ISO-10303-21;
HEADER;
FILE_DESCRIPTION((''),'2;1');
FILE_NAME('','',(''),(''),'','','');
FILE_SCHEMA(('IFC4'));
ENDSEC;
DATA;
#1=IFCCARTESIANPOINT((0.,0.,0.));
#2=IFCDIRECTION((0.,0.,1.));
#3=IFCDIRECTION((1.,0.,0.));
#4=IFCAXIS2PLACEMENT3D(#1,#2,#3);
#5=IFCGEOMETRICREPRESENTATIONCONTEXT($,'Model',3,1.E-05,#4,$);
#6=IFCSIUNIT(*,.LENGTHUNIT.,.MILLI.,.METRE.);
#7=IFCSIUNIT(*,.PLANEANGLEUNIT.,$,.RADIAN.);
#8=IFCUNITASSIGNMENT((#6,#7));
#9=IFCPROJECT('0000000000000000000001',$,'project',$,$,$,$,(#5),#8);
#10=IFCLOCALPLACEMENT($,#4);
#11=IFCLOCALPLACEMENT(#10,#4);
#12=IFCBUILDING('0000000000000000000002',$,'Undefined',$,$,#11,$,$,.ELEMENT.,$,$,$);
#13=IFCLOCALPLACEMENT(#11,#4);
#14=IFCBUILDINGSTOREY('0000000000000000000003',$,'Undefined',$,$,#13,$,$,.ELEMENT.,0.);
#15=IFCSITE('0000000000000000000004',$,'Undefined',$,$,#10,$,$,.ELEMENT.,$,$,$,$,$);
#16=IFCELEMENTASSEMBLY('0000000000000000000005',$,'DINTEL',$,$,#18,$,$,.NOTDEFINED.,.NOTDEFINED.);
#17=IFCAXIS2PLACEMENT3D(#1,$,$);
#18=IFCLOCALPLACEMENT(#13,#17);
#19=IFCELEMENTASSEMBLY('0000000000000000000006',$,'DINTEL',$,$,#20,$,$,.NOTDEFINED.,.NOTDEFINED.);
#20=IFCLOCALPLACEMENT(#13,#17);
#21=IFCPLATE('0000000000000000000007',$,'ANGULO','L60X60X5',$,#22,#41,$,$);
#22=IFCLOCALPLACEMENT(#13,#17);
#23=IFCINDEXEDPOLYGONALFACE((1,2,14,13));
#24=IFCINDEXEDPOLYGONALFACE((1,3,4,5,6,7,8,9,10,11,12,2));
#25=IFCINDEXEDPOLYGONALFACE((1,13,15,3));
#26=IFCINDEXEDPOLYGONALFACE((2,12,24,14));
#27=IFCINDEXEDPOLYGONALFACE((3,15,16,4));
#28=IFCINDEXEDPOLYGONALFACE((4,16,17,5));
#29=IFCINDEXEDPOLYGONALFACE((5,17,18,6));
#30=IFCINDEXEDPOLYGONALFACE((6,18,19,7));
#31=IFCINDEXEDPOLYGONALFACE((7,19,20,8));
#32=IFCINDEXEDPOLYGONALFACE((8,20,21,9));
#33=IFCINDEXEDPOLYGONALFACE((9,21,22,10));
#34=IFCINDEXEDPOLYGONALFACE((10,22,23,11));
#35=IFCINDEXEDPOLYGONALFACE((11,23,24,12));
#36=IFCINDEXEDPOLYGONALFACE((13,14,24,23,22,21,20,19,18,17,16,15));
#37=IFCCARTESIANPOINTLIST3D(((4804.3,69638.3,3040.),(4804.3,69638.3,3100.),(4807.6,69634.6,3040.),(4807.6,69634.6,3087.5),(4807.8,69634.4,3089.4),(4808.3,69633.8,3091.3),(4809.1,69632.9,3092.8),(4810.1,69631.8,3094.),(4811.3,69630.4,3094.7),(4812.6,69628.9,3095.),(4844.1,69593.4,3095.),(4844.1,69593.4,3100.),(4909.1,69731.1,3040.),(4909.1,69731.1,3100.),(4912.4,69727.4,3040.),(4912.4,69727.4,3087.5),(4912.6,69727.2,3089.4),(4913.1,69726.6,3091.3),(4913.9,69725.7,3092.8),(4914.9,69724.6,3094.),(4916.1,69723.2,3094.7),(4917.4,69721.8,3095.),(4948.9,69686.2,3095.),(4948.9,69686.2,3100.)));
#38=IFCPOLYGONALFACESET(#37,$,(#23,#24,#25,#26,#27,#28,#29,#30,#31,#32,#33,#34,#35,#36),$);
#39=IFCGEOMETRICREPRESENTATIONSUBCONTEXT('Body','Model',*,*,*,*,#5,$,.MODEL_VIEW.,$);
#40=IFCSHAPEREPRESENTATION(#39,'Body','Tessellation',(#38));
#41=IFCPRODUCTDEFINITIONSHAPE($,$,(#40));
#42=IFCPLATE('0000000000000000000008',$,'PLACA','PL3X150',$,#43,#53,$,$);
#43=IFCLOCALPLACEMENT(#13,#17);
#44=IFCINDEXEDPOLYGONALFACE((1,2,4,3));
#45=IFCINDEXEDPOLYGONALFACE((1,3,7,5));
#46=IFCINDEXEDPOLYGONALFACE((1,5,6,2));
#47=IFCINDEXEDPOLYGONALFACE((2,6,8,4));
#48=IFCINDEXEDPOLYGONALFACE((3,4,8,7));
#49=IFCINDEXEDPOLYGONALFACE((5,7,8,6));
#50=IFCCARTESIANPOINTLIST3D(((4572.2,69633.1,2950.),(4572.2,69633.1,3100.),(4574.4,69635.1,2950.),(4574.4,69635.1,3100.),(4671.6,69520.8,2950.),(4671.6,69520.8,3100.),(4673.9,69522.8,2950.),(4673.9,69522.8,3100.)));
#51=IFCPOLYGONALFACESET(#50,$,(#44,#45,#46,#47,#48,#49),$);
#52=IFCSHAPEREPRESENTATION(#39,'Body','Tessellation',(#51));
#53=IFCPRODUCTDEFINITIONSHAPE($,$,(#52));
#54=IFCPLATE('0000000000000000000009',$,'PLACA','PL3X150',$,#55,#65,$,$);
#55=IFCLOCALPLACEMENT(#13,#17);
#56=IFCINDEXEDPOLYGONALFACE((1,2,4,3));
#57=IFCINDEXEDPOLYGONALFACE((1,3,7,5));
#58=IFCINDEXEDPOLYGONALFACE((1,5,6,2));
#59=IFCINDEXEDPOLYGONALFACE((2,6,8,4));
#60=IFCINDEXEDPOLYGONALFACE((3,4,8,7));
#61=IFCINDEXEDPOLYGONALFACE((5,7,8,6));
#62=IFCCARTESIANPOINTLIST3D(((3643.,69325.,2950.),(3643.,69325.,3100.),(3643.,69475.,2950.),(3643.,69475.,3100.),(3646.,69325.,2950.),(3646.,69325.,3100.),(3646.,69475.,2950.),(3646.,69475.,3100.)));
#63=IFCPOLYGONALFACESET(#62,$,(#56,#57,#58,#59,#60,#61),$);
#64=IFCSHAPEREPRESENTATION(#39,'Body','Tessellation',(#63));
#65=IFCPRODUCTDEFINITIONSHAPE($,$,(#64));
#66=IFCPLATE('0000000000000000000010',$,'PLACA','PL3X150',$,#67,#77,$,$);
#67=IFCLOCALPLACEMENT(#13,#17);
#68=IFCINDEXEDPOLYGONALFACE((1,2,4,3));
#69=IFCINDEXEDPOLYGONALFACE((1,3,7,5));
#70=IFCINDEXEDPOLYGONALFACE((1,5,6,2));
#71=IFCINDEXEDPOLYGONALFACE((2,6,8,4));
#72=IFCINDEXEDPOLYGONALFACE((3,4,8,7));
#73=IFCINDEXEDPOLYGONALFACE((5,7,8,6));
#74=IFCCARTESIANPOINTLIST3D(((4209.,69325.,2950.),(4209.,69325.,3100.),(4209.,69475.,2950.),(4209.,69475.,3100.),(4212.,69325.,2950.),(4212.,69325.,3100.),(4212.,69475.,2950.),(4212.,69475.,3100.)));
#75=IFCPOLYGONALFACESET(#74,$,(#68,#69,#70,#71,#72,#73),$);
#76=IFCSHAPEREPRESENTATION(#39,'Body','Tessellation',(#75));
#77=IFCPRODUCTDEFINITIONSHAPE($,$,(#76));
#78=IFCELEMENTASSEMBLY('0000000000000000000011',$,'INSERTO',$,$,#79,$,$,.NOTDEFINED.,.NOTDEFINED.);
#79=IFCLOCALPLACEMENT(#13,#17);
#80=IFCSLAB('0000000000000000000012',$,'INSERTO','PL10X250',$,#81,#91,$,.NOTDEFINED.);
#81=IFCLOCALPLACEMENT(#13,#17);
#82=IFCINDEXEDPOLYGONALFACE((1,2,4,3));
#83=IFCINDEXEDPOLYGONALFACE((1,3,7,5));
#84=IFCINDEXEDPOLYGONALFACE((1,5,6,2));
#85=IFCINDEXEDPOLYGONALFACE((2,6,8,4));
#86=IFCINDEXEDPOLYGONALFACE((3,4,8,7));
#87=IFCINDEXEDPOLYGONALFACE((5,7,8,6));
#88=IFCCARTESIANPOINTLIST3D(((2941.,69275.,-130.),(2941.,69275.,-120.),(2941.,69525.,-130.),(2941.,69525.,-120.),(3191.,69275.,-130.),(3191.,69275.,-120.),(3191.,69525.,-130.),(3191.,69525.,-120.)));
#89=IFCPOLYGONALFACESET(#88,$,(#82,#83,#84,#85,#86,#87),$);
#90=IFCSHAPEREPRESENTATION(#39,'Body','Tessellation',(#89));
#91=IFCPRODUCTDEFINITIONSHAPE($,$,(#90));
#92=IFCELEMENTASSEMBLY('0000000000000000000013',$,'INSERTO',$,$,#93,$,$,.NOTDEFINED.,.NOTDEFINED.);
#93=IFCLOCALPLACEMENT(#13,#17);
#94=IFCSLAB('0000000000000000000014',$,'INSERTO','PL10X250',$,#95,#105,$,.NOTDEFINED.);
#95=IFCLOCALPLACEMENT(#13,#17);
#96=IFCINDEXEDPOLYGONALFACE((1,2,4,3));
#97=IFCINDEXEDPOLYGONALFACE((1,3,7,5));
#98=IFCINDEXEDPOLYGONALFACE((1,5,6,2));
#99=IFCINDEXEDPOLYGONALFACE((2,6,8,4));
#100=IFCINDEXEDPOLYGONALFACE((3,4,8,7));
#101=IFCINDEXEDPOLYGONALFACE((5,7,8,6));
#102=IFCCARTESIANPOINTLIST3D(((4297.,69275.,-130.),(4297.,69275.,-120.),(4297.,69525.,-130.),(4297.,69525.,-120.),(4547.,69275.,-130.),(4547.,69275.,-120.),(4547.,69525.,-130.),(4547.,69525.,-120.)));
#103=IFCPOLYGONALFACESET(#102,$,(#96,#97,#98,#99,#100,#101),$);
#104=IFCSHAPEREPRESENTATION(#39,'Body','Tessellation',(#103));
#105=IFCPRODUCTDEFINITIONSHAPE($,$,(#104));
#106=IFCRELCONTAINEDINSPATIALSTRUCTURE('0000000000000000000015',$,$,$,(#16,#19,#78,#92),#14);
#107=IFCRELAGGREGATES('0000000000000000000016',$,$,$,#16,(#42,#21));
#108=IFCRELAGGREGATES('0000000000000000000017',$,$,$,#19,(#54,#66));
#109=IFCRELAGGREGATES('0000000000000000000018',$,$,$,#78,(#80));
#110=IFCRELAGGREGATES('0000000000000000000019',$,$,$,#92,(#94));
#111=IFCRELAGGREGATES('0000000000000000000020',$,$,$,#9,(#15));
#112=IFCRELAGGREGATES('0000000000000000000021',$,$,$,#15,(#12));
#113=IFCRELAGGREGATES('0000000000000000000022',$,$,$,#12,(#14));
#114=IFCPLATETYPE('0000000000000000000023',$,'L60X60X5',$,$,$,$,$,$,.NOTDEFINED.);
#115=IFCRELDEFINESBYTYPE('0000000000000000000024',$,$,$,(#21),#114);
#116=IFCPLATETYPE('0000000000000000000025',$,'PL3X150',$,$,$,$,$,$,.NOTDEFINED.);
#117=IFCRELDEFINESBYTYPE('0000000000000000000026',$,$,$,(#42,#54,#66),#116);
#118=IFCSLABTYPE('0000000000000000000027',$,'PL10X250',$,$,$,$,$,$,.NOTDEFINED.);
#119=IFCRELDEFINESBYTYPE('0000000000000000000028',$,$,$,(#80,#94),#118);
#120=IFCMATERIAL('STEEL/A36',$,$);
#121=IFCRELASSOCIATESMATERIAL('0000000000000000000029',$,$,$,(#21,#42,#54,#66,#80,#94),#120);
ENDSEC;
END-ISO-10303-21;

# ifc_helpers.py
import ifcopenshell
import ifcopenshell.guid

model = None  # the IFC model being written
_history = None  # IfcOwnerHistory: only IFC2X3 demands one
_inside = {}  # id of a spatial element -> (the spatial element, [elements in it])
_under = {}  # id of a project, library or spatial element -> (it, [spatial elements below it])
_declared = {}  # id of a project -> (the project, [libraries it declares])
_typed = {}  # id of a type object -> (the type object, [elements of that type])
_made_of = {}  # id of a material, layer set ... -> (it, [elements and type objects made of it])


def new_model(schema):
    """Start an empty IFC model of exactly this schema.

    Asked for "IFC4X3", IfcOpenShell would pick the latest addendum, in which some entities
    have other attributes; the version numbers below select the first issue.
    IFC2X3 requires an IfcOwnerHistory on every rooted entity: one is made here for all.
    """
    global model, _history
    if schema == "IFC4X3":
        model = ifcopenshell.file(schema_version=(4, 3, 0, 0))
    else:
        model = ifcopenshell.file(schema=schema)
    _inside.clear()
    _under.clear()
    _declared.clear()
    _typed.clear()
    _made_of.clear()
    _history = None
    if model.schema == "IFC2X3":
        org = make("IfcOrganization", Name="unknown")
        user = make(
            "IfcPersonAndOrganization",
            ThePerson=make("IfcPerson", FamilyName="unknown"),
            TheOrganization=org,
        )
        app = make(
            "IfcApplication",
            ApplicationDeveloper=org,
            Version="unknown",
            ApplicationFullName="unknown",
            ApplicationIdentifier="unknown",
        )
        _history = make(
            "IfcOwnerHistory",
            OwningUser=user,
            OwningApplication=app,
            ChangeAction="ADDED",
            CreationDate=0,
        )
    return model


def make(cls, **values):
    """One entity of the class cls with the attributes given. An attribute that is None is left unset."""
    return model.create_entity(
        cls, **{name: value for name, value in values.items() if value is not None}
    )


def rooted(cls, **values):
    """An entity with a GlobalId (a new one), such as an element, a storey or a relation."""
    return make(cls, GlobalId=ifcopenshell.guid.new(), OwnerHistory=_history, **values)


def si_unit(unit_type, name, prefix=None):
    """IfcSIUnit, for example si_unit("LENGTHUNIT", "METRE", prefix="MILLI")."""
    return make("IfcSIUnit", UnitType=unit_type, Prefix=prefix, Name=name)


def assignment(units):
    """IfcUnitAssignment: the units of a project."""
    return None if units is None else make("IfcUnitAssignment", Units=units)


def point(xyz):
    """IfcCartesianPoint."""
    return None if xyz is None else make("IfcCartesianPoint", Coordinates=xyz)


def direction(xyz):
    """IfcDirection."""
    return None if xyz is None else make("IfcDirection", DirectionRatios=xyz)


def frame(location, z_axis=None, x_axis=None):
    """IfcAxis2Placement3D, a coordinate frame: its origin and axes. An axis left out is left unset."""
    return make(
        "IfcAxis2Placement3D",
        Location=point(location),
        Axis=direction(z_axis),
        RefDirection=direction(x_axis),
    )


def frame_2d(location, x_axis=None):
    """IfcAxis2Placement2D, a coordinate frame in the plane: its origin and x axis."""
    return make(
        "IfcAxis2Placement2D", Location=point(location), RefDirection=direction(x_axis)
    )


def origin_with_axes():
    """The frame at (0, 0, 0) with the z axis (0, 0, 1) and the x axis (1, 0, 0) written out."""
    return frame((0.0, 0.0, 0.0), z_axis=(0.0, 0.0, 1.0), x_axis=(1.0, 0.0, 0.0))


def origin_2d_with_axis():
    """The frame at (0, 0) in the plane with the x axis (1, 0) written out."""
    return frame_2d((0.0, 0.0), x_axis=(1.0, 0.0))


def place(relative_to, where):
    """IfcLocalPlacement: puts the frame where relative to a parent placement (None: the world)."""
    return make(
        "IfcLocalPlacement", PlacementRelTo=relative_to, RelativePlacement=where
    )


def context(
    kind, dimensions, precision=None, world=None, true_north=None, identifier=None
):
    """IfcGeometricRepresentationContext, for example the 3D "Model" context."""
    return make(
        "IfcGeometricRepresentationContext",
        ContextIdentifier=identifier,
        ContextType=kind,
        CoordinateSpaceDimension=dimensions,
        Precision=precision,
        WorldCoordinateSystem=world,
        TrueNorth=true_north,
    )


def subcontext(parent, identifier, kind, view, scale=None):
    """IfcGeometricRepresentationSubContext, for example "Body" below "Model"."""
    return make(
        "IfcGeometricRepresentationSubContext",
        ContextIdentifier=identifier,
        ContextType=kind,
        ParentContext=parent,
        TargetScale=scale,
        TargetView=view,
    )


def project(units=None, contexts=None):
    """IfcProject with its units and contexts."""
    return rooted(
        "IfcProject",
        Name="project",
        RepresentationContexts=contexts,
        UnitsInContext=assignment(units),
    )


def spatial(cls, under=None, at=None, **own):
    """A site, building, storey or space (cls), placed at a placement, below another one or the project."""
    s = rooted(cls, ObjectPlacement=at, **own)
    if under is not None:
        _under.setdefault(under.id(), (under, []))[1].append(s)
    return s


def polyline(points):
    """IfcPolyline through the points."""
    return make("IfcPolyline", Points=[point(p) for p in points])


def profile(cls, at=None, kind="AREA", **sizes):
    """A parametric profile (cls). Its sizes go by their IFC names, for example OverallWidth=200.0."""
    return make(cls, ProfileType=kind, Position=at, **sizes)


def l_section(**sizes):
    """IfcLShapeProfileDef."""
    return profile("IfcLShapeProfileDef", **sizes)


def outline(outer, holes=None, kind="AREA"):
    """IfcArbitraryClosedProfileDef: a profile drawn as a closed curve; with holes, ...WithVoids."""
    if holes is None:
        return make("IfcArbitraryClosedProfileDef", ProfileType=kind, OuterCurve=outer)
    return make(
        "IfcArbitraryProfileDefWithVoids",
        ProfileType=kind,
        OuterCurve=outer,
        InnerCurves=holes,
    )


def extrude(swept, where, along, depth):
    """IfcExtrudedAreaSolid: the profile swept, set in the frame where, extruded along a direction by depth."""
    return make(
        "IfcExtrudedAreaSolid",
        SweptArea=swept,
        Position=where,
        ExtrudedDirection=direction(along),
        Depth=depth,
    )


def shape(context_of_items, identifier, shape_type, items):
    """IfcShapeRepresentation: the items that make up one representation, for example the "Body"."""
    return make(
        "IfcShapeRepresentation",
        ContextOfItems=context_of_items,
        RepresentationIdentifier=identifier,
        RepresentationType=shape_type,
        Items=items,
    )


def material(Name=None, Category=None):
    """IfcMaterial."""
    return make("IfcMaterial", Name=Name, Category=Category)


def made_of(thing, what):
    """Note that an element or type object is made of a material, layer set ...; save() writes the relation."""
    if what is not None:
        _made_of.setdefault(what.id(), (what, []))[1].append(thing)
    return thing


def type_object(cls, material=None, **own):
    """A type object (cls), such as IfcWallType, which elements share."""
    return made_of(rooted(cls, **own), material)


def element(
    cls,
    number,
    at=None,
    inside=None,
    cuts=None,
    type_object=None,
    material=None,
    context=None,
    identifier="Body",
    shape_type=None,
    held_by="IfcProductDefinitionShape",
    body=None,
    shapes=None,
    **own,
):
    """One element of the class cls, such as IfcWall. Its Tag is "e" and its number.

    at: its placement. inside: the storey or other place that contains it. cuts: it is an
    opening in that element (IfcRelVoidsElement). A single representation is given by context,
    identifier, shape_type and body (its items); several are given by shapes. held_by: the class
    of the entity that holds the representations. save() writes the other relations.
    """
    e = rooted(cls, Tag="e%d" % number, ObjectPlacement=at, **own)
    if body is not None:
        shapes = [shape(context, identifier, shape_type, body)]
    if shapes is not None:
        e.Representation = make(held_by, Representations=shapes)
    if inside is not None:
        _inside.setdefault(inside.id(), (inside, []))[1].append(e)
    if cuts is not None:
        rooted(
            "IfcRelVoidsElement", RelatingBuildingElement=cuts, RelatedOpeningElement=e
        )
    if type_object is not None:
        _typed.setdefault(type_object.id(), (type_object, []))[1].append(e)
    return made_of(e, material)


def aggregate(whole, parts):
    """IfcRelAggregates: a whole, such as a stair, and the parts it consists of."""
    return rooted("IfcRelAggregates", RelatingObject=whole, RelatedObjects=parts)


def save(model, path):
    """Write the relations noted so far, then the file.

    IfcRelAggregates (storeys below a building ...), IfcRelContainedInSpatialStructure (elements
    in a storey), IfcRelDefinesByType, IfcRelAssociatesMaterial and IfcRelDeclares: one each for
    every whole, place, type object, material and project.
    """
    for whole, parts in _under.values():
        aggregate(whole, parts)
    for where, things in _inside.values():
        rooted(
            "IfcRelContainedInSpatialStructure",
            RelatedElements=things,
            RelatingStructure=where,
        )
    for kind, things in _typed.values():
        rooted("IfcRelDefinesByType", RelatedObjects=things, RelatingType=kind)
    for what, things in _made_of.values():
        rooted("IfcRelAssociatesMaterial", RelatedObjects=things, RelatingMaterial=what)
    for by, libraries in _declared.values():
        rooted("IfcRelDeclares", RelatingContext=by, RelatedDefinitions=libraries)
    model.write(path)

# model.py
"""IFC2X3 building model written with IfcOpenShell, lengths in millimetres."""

from ifc_helpers import new_model, si_unit, frame, origin_with_axes, origin_2d_with_axis, place, context, subcontext, project, spatial, polyline, l_section, outline, extrude, material, type_object, element, aggregate, save


model = new_model("IFC2X3")

# Units and contexts
model_context = context("Model", 3, precision=1e-05, world=origin_with_axes())
body_context = subcontext(model_context, "Body", "Model", "MODEL_VIEW")
ifc_project = project(units=[si_unit("LENGTHUNIT", "METRE", prefix="MILLI"), si_unit("PLANEANGLEUNIT", "RADIAN")], contexts=[model_context])

# Site, building, storey
site_placement = place(None, origin_with_axes())
site = spatial("IfcSite", under=ifc_project, at=site_placement, Name="Undefined", CompositionType="ELEMENT")
building_placement = place(site_placement, origin_with_axes())
building = spatial("IfcBuilding", under=site, at=building_placement, Name="Undefined", CompositionType="ELEMENT")
storey_placement = place(building_placement, origin_with_axes())
storey = spatial("IfcBuildingStorey", under=building, at=storey_placement, Name="Undefined", CompositionType="ELEMENT", Elevation=0.0)

# Element assemblies
assembly_1_placement = place(storey_placement, origin_with_axes())
assembly_1 = element("IfcElementAssembly", 1, at=assembly_1_placement, inside=storey, Name="DINTEL", AssemblyPlace="NOTDEFINED", PredefinedType="NOTDEFINED")
ifc_material_1 = material(Name="STEEL/A36")
assembly_2_placement = place(storey_placement, origin_with_axes())
assembly_2 = element("IfcElementAssembly", 2, at=assembly_2_placement, inside=storey, Name="DINTEL", AssemblyPlace="NOTDEFINED", PredefinedType="NOTDEFINED")

# Plates
plate_type_1 = type_object("IfcPlateType", Name="L60X60X5", PredefinedType="NOTDEFINED")
plate_1_placement = place(assembly_1_placement, frame((4929.0, 69708.7, 3070.0), z_axis=(0.0, 0.0, -1.0), x_axis=(-0.748701, -0.662908, 0.0)))
plate_1 = element("IfcPlate", 3, at=plate_1_placement, type_object=plate_type_1, material=ifc_material_1, Name="ANGULO", Description="L60X60X5", context=body_context, shape_type="SweptSolid", body=[
    extrude(l_section(Depth=60.0, Width=60.0, Thickness=5.0, FilletRadius=7.5, at=origin_2d_with_axis()), frame((140.0, 0.0, 0.0), z_axis=(-1.0, 0.0, 0.0), x_axis=(0.0, -1.0, 0.0)), (0.0, 0.0, 1.0), 140.0),
])
plate_type_2 = type_object("IfcPlateType", Name="PL3X150", PredefinedType="NOTDEFINED")
plate_2_placement = place(assembly_1_placement, frame((4672.7, 69521.8, 2950.0), z_axis=(0.7487, 0.662909, 0.0), x_axis=(-0.662909, 0.7487, 0.0)))
plate_2 = element("IfcPlate", 4, at=plate_2_placement, type_object=plate_type_2, material=ifc_material_1, Name="PLACA", Description="PL3X150", context=body_context, shape_type="SweptSolid", body=[
    extrude(outline(polyline([(0.0, 0.0), (150.0, 0.0), (150.0, 150.0), (0.0, 150.0), (0.0, 0.0)])), frame((0.0, 0.0, -1.5), z_axis=(0.0, 0.0, 1.0), x_axis=(1.0, 0.0, 0.0)), (0.0, 0.0, 1.0), 3.0),
])
aggregate(assembly_1, [plate_2, plate_1])
plate_3_placement = place(assembly_2_placement, frame((3644.5, 69325.0, 2950.0), z_axis=(1.0, 0.0, 0.0), x_axis=(0.0, 1.0, 0.0)))
plate_3 = element("IfcPlate", 5, at=plate_3_placement, type_object=plate_type_2, material=ifc_material_1, Name="PLACA", Description="PL3X150", context=body_context, shape_type="SweptSolid", body=[
    extrude(outline(polyline([(0.0, 0.0), (150.0, 0.0), (150.0, 150.0), (0.0, 150.0), (0.0, 0.0)])), frame((0.0, 0.0, -1.5), z_axis=(0.0, 0.0, 1.0), x_axis=(1.0, 0.0, 0.0)), (0.0, 0.0, 1.0), 3.0),
])
plate_4_placement = place(assembly_2_placement, frame((4210.5, 69475.0, 2950.0), z_axis=(-1.0, 0.0, 0.0), x_axis=(0.0, -1.0, 0.0)))
plate_4 = element("IfcPlate", 6, at=plate_4_placement, type_object=plate_type_2, material=ifc_material_1, Name="PLACA", Description="PL3X150", context=body_context, shape_type="SweptSolid", body=[
    extrude(outline(polyline([(0.0, 0.0), (150.0, 0.0), (150.0, 150.0), (0.0, 150.0), (0.0, 0.0)])), frame((0.0, 0.0, -1.5), z_axis=(0.0, 0.0, 1.0), x_axis=(1.0, 0.0, 0.0)), (0.0, 0.0, 1.0), 3.0),
])
aggregate(assembly_2, [plate_3, plate_4])

# Element assemblies, slabs
assembly_3_placement = place(storey_placement, origin_with_axes())
assembly_3 = element("IfcElementAssembly", 7, at=assembly_3_placement, inside=storey, Name="INSERTO", AssemblyPlace="NOTDEFINED", PredefinedType="NOTDEFINED")
slab_type = type_object("IfcSlabType", Name="PL10X250", PredefinedType="NOTDEFINED")
slab_1_placement = place(assembly_3_placement, frame((2941.0, 69275.0, -125.0), z_axis=(0.0, 0.0, 1.0), x_axis=(1.0, 0.0, 0.0)))
slab_1 = element("IfcSlab", 8, at=slab_1_placement, type_object=slab_type, material=ifc_material_1, Name="INSERTO", Description="PL10X250", PredefinedType="NOTDEFINED", context=body_context, shape_type="SweptSolid", body=[
    extrude(outline(polyline([(0.0, 0.0), (250.0, 0.0), (250.0, 250.0), (0.0, 250.0), (0.0, 0.0)])), frame((0.0, 0.0, -5.0), z_axis=(0.0, 0.0, 1.0), x_axis=(1.0, 0.0, 0.0)), (0.0, 0.0, 1.0), 10.0),
])
assembly_4_placement = place(storey_placement, origin_with_axes())
assembly_4 = element("IfcElementAssembly", 9, at=assembly_4_placement, inside=storey, Name="INSERTO", AssemblyPlace="NOTDEFINED", PredefinedType="NOTDEFINED")
slab_2_placement = place(assembly_4_placement, frame((4297.0, 69275.0, -125.0), z_axis=(0.0, 0.0, 1.0), x_axis=(1.0, 0.0, 0.0)))
slab_2 = element("IfcSlab", 10, at=slab_2_placement, type_object=slab_type, material=ifc_material_1, Name="INSERTO", Description="PL10X250", PredefinedType="NOTDEFINED", context=body_context, shape_type="SweptSolid", body=[
    extrude(outline(polyline([(0.0, 0.0), (250.0, 0.0), (250.0, 250.0), (0.0, 250.0), (0.0, 0.0)])), frame((0.0, 0.0, -5.0), z_axis=(0.0, 0.0, 1.0), x_axis=(1.0, 0.0, 0.0)), (0.0, 0.0, 1.0), 10.0),
])

aggregate(assembly_3, [slab_1])
aggregate(assembly_4, [slab_2])

save(model, "model.ifc")
